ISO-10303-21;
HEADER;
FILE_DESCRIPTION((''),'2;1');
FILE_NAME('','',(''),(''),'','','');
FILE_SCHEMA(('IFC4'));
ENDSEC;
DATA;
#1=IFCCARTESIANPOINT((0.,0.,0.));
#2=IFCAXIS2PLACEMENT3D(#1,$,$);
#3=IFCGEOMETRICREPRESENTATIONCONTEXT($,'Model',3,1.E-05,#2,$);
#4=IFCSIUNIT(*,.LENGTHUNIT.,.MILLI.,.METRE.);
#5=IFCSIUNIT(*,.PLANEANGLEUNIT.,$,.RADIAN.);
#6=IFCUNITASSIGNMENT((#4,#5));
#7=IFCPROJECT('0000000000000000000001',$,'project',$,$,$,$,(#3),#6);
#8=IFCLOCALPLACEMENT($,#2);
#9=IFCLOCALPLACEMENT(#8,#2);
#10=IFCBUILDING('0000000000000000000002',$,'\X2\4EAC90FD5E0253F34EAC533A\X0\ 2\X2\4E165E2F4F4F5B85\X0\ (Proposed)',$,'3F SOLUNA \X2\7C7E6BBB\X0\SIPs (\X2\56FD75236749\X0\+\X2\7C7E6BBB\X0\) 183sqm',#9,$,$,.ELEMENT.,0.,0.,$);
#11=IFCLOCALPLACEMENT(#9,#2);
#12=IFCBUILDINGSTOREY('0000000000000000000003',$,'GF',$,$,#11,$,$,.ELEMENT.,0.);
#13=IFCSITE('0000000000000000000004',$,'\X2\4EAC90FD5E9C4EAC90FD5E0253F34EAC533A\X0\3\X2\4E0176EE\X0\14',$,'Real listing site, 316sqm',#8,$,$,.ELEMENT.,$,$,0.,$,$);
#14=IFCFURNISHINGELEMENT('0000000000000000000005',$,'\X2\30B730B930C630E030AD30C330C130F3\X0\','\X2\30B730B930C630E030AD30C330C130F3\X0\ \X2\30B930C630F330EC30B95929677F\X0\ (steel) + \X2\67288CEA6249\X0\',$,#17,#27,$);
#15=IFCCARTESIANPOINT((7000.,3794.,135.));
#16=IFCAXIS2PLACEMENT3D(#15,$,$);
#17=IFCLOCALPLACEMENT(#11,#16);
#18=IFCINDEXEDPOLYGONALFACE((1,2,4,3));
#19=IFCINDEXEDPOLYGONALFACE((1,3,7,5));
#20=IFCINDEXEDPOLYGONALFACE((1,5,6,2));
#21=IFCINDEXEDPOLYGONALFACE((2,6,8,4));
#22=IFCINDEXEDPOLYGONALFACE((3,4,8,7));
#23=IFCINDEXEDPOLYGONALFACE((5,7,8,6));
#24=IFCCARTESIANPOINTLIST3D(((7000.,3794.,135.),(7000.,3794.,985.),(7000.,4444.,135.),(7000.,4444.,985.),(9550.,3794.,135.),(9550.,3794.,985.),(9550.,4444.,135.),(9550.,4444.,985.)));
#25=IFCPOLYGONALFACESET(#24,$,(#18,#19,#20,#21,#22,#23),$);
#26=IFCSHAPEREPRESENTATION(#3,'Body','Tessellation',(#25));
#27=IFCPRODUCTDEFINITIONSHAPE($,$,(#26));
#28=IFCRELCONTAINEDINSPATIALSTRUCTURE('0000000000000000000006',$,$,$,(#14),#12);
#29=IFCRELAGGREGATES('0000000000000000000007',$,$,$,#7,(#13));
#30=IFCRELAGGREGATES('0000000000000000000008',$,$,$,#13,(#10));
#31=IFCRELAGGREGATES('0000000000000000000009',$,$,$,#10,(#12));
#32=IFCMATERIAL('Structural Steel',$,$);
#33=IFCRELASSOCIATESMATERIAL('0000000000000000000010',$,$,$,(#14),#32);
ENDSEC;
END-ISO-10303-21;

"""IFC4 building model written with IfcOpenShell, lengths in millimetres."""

from ifc_helpers import new_model, si_unit, frame, frame_2d, origin, place, context, project, spatial, rectangle, extrude, material, element, save


model = new_model("IFC4")

# Units and contexts
model_context = context("Model", 3, precision=1e-05, world=origin())
ifc_project = project(units=[si_unit("LENGTHUNIT", "METRE", prefix="MILLI"), si_unit("PLANEANGLEUNIT", "RADIAN")], contexts=[model_context])

# Site, building, storey
site_placement = place(None, origin())
site = spatial("IfcSite", under=ifc_project, at=site_placement, Name="京都府京都市右京区3丁目14", ObjectType="Real listing site, 316sqm", CompositionType="ELEMENT", RefElevation=0.0)
building_placement = place(site_placement, origin())
building = spatial("IfcBuilding", under=site, at=building_placement, Name="京都市右京区 2世帯住宅 (Proposed)", ObjectType="3F SOLUNA 籾殻SIPs (国産杉+籾殻) 183sqm", CompositionType="ELEMENT", ElevationOfRefHeight=0.0, ElevationOfTerrain=0.0)
storey_placement = place(building_placement, origin())
storey = spatial("IfcBuildingStorey", under=building, at=storey_placement, Name="GF", CompositionType="ELEMENT", Elevation=0.0)

# Furnishing element
ifc_material_1 = material(Name="Structural Steel")
furnishing_1_placement = place(storey_placement, frame((7000.0, 3794.0, 135.0)))
element("IfcFurnishingElement", 1, at=furnishing_1_placement, inside=storey, material=ifc_material_1, Name="システムキッチン", Description="システムキッチン ステンレス天板 (steel) + 木質扉", context=model_context, shape_type="SweptSolid", body=[
    extrude(rectangle(XDim=2550.0, YDim=650.0, at=frame_2d((1275.0, 325.0))), frame((7000.0, 3794.0, 135.0)), (0.0, 0.0, 1.0), 850.0),
])

save(model, "model.ifc")
